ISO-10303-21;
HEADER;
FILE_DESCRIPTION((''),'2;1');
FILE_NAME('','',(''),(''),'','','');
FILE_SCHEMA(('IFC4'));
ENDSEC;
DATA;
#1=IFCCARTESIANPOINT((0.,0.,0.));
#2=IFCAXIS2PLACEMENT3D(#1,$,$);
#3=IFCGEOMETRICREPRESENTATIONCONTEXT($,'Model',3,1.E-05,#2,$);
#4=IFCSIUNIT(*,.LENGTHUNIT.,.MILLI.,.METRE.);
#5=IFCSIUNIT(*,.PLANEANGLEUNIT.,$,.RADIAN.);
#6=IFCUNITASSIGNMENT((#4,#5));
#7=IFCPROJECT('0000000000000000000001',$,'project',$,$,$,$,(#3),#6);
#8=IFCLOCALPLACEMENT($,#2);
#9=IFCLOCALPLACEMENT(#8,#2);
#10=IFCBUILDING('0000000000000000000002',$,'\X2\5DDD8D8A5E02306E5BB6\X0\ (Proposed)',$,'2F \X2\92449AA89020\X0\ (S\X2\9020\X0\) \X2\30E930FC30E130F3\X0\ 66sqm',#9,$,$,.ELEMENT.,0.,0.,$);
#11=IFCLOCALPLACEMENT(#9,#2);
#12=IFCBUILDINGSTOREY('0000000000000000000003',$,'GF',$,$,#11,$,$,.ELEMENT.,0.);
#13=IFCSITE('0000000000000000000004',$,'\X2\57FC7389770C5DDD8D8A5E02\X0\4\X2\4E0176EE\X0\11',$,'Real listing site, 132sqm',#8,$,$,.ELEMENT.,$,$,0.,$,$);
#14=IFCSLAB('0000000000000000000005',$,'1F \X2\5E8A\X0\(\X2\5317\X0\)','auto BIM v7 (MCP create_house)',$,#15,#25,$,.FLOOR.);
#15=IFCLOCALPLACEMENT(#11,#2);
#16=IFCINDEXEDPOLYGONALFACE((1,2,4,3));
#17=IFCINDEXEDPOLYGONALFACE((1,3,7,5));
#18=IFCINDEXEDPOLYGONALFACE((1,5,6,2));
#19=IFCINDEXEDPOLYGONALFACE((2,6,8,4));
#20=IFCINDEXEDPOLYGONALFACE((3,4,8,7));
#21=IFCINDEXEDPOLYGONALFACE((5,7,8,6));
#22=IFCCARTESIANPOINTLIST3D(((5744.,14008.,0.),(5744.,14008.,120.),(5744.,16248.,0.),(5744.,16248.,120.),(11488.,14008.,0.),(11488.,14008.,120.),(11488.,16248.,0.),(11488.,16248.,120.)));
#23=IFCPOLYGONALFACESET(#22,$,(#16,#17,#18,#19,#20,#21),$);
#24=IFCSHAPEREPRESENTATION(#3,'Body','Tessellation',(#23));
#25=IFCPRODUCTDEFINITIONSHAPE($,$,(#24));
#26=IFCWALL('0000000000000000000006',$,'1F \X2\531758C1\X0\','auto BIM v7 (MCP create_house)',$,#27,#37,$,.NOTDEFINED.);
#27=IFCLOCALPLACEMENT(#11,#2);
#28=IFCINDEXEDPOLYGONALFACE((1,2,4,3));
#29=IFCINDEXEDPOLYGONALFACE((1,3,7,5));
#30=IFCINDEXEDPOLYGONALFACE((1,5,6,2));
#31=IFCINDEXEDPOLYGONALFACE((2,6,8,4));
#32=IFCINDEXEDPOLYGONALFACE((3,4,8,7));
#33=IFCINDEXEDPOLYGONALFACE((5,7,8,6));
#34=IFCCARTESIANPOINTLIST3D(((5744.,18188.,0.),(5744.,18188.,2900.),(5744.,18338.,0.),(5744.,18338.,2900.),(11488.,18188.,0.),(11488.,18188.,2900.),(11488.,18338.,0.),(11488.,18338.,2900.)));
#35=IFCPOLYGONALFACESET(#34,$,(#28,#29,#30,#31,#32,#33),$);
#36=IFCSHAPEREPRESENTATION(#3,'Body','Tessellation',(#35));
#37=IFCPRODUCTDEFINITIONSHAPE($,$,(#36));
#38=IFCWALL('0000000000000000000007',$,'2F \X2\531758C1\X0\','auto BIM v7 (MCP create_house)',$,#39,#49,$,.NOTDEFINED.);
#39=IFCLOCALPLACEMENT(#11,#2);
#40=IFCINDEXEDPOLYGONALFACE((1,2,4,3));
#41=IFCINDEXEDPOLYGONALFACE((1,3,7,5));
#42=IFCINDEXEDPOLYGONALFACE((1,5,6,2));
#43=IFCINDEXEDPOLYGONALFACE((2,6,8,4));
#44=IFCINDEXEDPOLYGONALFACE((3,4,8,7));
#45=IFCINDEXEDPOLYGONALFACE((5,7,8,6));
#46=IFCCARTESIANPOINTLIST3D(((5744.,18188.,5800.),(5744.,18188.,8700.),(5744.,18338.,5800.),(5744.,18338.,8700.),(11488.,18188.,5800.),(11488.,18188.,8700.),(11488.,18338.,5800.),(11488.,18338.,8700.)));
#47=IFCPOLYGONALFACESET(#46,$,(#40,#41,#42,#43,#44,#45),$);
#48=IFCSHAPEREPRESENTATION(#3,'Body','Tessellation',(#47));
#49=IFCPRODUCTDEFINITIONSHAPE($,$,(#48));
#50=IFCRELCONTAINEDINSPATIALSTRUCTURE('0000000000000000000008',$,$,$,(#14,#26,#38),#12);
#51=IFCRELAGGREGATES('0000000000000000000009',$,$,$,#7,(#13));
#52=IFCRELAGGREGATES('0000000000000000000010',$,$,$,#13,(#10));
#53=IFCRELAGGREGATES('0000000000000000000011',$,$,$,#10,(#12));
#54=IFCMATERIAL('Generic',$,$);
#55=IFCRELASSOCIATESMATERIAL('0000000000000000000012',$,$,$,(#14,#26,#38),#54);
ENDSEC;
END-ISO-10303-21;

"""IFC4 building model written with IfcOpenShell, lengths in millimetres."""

from ifc_helpers import new_model, si_unit, frame, frame_2d, origin, place, context, project, spatial, rectangle, extrude, material, element, save


model = new_model("IFC4")

# Units and contexts
model_context = context("Model", 3, precision=1e-05, world=origin())
ifc_project = project(units=[si_unit("LENGTHUNIT", "METRE", prefix="MILLI"), si_unit("PLANEANGLEUNIT", "RADIAN")], contexts=[model_context])

# Site, building, storey
site_placement = place(None, origin())
site = spatial("IfcSite", under=ifc_project, at=site_placement, Name="埼玉県川越市4丁目11", ObjectType="Real listing site, 132sqm", CompositionType="ELEMENT", RefElevation=0.0)
building_placement = place(site_placement, origin())
building = spatial("IfcBuilding", under=site, at=building_placement, Name="川越市の家 (Proposed)", ObjectType="2F 鉄骨造 (S造) ラーメン 66sqm", CompositionType="ELEMENT", ElevationOfRefHeight=0.0, ElevationOfTerrain=0.0)
storey_placement = place(building_placement, origin())
storey = spatial("IfcBuildingStorey", under=building, at=storey_placement, Name="GF", CompositionType="ELEMENT", Elevation=0.0)

# Slab
ifc_material = material(Name="Generic")
slab_1_placement = place(storey_placement, frame((2872.0, 7004.0, 0.0)))
element("IfcSlab", 1, at=slab_1_placement, inside=storey, material=ifc_material, Name="1F 床(北)", Description="auto BIM v7 (MCP create_house)", PredefinedType="FLOOR", context=model_context, shape_type="SweptSolid", body=[
    extrude(rectangle(XDim=5744.0, YDim=2240.0, at=frame_2d((2872.0, 1120.0))), frame((2872.0, 7004.0, 0.0)), (0.0, 0.0, 1.0), 120.0),
])

# Wall
wall_1_placement = place(storey_placement, frame((2872.0, 9094.0, 0.0)))
element("IfcWall", 2, at=wall_1_placement, inside=storey, material=ifc_material, Name="1F 北壁", Description="auto BIM v7 (MCP create_house)", PredefinedType="NOTDEFINED", context=model_context, shape_type="SweptSolid", body=[
    extrude(rectangle(XDim=5744.0, YDim=150.0, at=frame_2d((2872.0, 75.0))), frame((2872.0, 9094.0, 0.0)), (0.0, 0.0, 1.0), 2900.0),
])

# Wall
wall_2_placement = place(storey_placement, frame((2872.0, 9094.0, 2900.0)))
element("IfcWall", 3, at=wall_2_placement, inside=storey, material=ifc_material, Name="2F 北壁", Description="auto BIM v7 (MCP create_house)", PredefinedType="NOTDEFINED", context=model_context, shape_type="SweptSolid", body=[
    extrude(rectangle(XDim=5744.0, YDim=150.0, at=frame_2d((2872.0, 75.0))), frame((2872.0, 9094.0, 2900.0)), (0.0, 0.0, 1.0), 2900.0),
])

save(model, "model.ifc")
